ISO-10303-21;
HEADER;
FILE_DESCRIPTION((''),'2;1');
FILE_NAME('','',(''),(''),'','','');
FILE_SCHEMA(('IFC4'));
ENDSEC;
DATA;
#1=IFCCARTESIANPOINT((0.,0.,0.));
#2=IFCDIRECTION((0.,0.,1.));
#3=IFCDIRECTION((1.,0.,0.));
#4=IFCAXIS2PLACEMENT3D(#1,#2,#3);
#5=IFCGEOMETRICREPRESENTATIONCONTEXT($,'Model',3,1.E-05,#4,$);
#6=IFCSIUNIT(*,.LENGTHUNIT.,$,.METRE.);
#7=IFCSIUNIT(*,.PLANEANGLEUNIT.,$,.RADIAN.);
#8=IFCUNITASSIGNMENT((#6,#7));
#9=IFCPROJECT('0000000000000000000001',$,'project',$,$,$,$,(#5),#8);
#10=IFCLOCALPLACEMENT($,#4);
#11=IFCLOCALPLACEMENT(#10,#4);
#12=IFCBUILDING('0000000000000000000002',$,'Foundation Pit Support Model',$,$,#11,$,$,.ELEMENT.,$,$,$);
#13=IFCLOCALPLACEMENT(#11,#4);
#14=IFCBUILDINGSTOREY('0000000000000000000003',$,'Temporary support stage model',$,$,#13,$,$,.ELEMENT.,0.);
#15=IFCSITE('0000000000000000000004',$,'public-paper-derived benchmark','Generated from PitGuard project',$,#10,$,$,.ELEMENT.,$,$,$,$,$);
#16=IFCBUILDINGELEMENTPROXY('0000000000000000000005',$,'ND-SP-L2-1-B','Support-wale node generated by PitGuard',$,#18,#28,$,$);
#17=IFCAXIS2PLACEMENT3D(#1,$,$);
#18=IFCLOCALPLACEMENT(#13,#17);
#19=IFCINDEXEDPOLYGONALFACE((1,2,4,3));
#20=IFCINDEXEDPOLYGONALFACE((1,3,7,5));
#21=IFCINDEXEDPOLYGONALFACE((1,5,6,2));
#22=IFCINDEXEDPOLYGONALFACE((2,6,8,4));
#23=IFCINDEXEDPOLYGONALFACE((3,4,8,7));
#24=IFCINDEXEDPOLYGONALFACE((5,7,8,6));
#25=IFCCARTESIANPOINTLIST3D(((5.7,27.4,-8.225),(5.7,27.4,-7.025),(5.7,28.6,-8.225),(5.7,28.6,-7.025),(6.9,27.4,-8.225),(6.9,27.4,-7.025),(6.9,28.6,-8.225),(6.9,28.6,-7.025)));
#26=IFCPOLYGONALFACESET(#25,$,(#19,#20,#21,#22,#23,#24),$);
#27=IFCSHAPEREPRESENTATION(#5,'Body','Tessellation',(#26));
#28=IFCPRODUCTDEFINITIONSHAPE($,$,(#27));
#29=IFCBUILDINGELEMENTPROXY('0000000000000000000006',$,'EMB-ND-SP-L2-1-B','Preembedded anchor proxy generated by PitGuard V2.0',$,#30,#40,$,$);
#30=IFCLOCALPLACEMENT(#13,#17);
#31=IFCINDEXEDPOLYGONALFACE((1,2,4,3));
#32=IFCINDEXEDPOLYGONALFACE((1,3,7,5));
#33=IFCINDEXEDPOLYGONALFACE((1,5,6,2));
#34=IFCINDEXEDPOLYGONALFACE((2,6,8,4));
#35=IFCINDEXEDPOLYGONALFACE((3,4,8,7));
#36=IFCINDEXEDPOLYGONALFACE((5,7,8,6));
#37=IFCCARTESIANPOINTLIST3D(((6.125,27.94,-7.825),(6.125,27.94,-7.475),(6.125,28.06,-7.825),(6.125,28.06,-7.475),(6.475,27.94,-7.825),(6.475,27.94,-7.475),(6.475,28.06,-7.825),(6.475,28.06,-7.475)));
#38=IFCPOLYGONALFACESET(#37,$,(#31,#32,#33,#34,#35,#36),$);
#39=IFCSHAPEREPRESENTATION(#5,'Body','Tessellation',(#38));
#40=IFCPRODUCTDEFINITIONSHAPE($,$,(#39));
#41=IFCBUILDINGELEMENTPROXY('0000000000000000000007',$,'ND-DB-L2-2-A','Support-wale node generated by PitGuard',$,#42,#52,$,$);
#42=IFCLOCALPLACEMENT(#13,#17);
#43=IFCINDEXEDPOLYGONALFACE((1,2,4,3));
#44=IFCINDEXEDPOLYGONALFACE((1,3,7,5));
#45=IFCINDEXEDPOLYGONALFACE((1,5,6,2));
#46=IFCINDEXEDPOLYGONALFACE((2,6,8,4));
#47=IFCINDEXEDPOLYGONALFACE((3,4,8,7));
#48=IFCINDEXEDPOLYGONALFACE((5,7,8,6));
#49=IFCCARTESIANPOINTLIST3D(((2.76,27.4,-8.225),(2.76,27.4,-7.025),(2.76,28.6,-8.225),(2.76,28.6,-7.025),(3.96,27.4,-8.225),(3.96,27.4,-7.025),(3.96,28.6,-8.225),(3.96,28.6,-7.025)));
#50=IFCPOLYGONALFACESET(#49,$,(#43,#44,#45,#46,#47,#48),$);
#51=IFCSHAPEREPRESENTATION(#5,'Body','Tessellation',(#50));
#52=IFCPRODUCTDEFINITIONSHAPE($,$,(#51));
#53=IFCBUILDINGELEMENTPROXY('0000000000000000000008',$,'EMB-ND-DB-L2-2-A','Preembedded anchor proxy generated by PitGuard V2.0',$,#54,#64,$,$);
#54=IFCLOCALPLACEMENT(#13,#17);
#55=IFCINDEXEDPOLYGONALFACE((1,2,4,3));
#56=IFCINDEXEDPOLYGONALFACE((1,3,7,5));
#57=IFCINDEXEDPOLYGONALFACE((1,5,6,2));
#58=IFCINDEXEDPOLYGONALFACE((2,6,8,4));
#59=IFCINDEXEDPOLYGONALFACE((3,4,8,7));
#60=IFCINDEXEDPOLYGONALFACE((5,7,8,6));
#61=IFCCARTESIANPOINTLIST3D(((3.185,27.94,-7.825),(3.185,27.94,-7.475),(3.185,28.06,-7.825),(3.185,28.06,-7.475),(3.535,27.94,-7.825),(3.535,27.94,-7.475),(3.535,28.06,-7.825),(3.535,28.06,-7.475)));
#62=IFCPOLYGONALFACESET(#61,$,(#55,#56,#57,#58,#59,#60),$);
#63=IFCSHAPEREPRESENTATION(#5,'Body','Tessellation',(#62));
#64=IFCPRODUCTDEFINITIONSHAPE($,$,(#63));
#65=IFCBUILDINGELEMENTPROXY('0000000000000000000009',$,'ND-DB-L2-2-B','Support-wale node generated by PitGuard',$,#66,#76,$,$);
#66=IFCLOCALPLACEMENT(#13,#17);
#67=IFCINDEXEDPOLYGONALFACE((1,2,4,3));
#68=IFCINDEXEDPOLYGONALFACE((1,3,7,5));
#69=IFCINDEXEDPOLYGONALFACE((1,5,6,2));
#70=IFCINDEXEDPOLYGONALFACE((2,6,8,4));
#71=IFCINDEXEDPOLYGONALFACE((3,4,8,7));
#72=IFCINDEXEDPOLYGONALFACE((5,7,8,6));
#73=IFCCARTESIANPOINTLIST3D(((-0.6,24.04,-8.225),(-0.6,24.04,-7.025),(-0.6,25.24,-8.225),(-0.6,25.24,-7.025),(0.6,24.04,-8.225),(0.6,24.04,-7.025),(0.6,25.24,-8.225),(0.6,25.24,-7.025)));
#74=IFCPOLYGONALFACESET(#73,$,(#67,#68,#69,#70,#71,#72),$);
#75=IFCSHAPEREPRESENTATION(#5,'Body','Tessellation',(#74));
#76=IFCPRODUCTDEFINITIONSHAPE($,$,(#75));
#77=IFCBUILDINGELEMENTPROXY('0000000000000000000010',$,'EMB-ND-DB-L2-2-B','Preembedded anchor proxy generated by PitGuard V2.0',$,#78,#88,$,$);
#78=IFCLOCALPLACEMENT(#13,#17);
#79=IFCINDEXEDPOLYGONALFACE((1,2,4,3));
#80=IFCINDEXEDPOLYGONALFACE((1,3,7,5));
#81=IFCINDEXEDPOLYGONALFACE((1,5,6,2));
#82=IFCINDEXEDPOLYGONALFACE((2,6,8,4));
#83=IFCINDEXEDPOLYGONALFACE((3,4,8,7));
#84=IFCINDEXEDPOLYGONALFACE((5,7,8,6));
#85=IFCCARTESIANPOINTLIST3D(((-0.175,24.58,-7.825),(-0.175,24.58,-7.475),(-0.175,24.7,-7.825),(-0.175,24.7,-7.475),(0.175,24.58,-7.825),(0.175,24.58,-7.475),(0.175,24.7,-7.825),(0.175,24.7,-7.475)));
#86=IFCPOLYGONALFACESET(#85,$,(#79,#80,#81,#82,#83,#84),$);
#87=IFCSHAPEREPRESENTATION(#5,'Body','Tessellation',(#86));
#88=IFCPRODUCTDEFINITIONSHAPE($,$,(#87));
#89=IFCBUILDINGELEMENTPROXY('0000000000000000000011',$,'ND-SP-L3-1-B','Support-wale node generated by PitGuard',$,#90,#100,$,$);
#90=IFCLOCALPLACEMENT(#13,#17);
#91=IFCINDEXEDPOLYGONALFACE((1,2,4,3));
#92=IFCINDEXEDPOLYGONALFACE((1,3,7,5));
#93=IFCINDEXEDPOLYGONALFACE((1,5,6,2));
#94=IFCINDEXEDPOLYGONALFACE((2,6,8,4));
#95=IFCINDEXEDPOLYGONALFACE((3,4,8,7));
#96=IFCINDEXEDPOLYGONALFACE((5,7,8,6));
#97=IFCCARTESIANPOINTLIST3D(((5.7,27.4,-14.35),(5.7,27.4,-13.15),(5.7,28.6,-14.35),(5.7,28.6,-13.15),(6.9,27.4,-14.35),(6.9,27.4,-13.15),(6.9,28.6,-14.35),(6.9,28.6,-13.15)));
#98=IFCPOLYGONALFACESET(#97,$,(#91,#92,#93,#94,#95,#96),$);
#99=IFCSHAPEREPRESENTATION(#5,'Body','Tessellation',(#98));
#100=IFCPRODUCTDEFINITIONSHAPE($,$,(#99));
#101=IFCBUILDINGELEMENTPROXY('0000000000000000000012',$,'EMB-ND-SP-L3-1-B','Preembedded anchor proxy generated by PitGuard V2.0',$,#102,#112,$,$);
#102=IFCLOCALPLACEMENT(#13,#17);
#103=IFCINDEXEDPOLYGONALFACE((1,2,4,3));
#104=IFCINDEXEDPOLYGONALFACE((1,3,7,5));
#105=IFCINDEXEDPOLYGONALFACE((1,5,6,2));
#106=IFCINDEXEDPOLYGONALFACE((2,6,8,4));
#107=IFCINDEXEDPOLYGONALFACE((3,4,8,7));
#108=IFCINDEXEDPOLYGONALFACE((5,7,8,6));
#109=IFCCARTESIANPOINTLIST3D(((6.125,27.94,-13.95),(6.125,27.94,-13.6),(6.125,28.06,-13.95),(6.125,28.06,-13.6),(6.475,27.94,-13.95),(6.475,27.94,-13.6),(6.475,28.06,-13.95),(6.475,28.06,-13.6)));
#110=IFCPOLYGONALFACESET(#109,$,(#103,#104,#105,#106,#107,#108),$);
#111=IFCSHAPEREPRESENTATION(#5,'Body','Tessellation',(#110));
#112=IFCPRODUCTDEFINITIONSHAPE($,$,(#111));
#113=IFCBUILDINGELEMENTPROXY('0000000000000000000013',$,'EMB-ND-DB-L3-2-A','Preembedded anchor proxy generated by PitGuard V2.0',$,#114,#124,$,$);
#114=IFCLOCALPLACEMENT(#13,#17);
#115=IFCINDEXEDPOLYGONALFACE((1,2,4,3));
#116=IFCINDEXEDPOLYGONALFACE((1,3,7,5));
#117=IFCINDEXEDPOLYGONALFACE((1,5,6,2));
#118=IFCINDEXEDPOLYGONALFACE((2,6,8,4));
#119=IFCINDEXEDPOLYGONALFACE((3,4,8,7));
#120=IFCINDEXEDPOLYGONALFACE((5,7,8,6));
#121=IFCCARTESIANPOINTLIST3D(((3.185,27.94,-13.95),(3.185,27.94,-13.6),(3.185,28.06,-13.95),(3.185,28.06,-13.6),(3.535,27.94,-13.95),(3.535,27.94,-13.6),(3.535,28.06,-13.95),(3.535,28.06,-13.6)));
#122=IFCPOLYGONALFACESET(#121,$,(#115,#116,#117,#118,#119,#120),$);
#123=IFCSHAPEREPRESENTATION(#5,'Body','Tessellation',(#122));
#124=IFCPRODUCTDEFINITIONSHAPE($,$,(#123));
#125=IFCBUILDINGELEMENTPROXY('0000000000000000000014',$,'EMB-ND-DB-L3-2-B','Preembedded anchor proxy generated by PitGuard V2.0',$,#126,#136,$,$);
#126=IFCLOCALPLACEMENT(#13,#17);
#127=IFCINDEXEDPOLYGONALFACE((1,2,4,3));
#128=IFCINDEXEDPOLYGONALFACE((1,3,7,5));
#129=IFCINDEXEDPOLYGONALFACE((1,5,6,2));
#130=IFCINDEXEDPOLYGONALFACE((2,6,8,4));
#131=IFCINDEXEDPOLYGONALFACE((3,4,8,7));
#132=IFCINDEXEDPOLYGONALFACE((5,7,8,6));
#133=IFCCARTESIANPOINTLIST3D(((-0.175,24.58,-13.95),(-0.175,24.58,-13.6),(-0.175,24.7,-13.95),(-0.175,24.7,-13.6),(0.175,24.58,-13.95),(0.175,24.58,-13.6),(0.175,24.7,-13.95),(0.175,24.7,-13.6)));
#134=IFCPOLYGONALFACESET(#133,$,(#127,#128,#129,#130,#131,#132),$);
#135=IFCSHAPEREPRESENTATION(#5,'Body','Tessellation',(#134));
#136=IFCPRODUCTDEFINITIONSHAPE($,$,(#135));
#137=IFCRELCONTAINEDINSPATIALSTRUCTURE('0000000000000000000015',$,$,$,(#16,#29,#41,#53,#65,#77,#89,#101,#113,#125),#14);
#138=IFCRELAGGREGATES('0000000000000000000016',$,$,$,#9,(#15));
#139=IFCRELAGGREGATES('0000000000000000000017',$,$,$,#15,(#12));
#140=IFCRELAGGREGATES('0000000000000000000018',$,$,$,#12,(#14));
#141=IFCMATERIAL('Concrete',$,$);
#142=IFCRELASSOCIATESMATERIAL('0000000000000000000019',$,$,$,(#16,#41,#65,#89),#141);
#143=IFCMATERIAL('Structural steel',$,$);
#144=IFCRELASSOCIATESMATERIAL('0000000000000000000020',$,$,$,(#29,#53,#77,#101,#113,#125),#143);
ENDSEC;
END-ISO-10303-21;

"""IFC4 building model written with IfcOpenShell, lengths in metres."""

from ifc_helpers import new_model, si_unit, frame, origin_with_axes, origin_2d, place, context, project, spatial, rectangle, extrude, material, element, save


model = new_model("IFC4")

# Units and contexts
model_context = context("Model", 3, precision=1e-05, world=origin_with_axes())
ifc_project = project(units=[si_unit("LENGTHUNIT", "METRE"), si_unit("PLANEANGLEUNIT", "RADIAN")], contexts=[model_context])

# Site, building, storey
site_placement = place(None, origin_with_axes())
site = spatial("IfcSite", under=ifc_project, at=site_placement, Name="public-paper-derived benchmark", Description="Generated from PitGuard project", CompositionType="ELEMENT")
building_placement = place(site_placement, origin_with_axes())
building = spatial("IfcBuilding", under=site, at=building_placement, Name="Foundation Pit Support Model", CompositionType="ELEMENT")
storey_placement = place(building_placement, origin_with_axes())
storey = spatial("IfcBuildingStorey", under=building, at=storey_placement, Name="Temporary support stage model", CompositionType="ELEMENT", Elevation=0.0)

# Shared definitions
ifc_material_1 = material(Name="Concrete")

# Shared definitions
ifc_material_2 = material(Name="Structural steel")

# Building element proxies
proxy_1_placement = place(storey_placement, frame((6.3, 28.0, -8.225), z_axis=(0.0, 0.0, 1.0), x_axis=(1.0, 0.0, 0.0)))
element("IfcBuildingElementProxy", 1, at=proxy_1_placement, inside=storey, material=ifc_material_1, Name="ND-SP-L2-1-B", Description="Support-wale node generated by PitGuard", context=model_context, shape_type="SweptSolid", body=[
    extrude(rectangle(XDim=1.2, YDim=1.2, at=origin_2d()), origin_with_axes(), (0.0, 0.0, 1.0), 1.2),
])
proxy_2_placement = place(storey_placement, frame((6.3, 28.0, -7.825), z_axis=(0.0, 0.0, 1.0), x_axis=(1.0, 0.0, 0.0)))
element("IfcBuildingElementProxy", 2, at=proxy_2_placement, inside=storey, material=ifc_material_2, Name="EMB-ND-SP-L2-1-B", Description="Preembedded anchor proxy generated by PitGuard V2.0", context=model_context, shape_type="SweptSolid", body=[
    extrude(rectangle(XDim=0.35, YDim=0.12, at=origin_2d()), origin_with_axes(), (0.0, 0.0, 1.0), 0.35),
])
proxy_3_placement = place(storey_placement, frame((3.36, 28.0, -8.225), z_axis=(0.0, 0.0, 1.0), x_axis=(1.0, 0.0, 0.0)))
element("IfcBuildingElementProxy", 3, at=proxy_3_placement, inside=storey, material=ifc_material_1, Name="ND-DB-L2-2-A", Description="Support-wale node generated by PitGuard", context=model_context, shape_type="SweptSolid", body=[
    extrude(rectangle(XDim=1.2, YDim=1.2, at=origin_2d()), origin_with_axes(), (0.0, 0.0, 1.0), 1.2),
])
proxy_4_placement = place(storey_placement, frame((3.36, 28.0, -7.825), z_axis=(0.0, 0.0, 1.0), x_axis=(1.0, 0.0, 0.0)))
element("IfcBuildingElementProxy", 4, at=proxy_4_placement, inside=storey, material=ifc_material_2, Name="EMB-ND-DB-L2-2-A", Description="Preembedded anchor proxy generated by PitGuard V2.0", context=model_context, shape_type="SweptSolid", body=[
    extrude(rectangle(XDim=0.35, YDim=0.12, at=origin_2d()), origin_with_axes(), (0.0, 0.0, 1.0), 0.35),
])
proxy_5_placement = place(storey_placement, frame((0.0, 24.64, -8.225), z_axis=(0.0, 0.0, 1.0), x_axis=(1.0, 0.0, 0.0)))
element("IfcBuildingElementProxy", 5, at=proxy_5_placement, inside=storey, material=ifc_material_1, Name="ND-DB-L2-2-B", Description="Support-wale node generated by PitGuard", context=model_context, shape_type="SweptSolid", body=[
    extrude(rectangle(XDim=1.2, YDim=1.2, at=origin_2d()), origin_with_axes(), (0.0, 0.0, 1.0), 1.2),
])
proxy_6_placement = place(storey_placement, frame((0.0, 24.64, -7.825), z_axis=(0.0, 0.0, 1.0), x_axis=(1.0, 0.0, 0.0)))
element("IfcBuildingElementProxy", 6, at=proxy_6_placement, inside=storey, material=ifc_material_2, Name="EMB-ND-DB-L2-2-B", Description="Preembedded anchor proxy generated by PitGuard V2.0", context=model_context, shape_type="SweptSolid", body=[
    extrude(rectangle(XDim=0.35, YDim=0.12, at=origin_2d()), origin_with_axes(), (0.0, 0.0, 1.0), 0.35),
])
proxy_7_placement = place(storey_placement, frame((6.3, 28.0, -14.35), z_axis=(0.0, 0.0, 1.0), x_axis=(1.0, 0.0, 0.0)))
element("IfcBuildingElementProxy", 7, at=proxy_7_placement, inside=storey, material=ifc_material_1, Name="ND-SP-L3-1-B", Description="Support-wale node generated by PitGuard", context=model_context, shape_type="SweptSolid", body=[
    extrude(rectangle(XDim=1.2, YDim=1.2, at=origin_2d()), origin_with_axes(), (0.0, 0.0, 1.0), 1.2),
])
for number, where, z_axis, x_axis, name in (
    (8, (6.3, 28.0, -13.95), (0.0, 0.0, 1.0), (1.0, 0.0, 0.0), "EMB-ND-SP-L3-1-B"),
    (9, (3.36, 28.0, -13.95), (0.0, 0.0, 1.0), (1.0, 0.0, 0.0), "EMB-ND-DB-L3-2-A"),
    (10, (0.0, 24.64, -13.95), (0.0, 0.0, 1.0), (1.0, 0.0, 0.0), "EMB-ND-DB-L3-2-B"),
):
    element("IfcBuildingElementProxy", number, at=place(storey_placement, frame(where, z_axis=z_axis, x_axis=x_axis)), inside=storey, material=ifc_material_2, Name=name, Description="Preembedded anchor proxy generated by PitGuard V2.0", context=model_context, shape_type="SweptSolid", body=[
        extrude(rectangle(XDim=0.35, YDim=0.12, at=origin_2d()), origin_with_axes(), (0.0, 0.0, 1.0), 0.35),
    ])

save(model, "model.ifc")
